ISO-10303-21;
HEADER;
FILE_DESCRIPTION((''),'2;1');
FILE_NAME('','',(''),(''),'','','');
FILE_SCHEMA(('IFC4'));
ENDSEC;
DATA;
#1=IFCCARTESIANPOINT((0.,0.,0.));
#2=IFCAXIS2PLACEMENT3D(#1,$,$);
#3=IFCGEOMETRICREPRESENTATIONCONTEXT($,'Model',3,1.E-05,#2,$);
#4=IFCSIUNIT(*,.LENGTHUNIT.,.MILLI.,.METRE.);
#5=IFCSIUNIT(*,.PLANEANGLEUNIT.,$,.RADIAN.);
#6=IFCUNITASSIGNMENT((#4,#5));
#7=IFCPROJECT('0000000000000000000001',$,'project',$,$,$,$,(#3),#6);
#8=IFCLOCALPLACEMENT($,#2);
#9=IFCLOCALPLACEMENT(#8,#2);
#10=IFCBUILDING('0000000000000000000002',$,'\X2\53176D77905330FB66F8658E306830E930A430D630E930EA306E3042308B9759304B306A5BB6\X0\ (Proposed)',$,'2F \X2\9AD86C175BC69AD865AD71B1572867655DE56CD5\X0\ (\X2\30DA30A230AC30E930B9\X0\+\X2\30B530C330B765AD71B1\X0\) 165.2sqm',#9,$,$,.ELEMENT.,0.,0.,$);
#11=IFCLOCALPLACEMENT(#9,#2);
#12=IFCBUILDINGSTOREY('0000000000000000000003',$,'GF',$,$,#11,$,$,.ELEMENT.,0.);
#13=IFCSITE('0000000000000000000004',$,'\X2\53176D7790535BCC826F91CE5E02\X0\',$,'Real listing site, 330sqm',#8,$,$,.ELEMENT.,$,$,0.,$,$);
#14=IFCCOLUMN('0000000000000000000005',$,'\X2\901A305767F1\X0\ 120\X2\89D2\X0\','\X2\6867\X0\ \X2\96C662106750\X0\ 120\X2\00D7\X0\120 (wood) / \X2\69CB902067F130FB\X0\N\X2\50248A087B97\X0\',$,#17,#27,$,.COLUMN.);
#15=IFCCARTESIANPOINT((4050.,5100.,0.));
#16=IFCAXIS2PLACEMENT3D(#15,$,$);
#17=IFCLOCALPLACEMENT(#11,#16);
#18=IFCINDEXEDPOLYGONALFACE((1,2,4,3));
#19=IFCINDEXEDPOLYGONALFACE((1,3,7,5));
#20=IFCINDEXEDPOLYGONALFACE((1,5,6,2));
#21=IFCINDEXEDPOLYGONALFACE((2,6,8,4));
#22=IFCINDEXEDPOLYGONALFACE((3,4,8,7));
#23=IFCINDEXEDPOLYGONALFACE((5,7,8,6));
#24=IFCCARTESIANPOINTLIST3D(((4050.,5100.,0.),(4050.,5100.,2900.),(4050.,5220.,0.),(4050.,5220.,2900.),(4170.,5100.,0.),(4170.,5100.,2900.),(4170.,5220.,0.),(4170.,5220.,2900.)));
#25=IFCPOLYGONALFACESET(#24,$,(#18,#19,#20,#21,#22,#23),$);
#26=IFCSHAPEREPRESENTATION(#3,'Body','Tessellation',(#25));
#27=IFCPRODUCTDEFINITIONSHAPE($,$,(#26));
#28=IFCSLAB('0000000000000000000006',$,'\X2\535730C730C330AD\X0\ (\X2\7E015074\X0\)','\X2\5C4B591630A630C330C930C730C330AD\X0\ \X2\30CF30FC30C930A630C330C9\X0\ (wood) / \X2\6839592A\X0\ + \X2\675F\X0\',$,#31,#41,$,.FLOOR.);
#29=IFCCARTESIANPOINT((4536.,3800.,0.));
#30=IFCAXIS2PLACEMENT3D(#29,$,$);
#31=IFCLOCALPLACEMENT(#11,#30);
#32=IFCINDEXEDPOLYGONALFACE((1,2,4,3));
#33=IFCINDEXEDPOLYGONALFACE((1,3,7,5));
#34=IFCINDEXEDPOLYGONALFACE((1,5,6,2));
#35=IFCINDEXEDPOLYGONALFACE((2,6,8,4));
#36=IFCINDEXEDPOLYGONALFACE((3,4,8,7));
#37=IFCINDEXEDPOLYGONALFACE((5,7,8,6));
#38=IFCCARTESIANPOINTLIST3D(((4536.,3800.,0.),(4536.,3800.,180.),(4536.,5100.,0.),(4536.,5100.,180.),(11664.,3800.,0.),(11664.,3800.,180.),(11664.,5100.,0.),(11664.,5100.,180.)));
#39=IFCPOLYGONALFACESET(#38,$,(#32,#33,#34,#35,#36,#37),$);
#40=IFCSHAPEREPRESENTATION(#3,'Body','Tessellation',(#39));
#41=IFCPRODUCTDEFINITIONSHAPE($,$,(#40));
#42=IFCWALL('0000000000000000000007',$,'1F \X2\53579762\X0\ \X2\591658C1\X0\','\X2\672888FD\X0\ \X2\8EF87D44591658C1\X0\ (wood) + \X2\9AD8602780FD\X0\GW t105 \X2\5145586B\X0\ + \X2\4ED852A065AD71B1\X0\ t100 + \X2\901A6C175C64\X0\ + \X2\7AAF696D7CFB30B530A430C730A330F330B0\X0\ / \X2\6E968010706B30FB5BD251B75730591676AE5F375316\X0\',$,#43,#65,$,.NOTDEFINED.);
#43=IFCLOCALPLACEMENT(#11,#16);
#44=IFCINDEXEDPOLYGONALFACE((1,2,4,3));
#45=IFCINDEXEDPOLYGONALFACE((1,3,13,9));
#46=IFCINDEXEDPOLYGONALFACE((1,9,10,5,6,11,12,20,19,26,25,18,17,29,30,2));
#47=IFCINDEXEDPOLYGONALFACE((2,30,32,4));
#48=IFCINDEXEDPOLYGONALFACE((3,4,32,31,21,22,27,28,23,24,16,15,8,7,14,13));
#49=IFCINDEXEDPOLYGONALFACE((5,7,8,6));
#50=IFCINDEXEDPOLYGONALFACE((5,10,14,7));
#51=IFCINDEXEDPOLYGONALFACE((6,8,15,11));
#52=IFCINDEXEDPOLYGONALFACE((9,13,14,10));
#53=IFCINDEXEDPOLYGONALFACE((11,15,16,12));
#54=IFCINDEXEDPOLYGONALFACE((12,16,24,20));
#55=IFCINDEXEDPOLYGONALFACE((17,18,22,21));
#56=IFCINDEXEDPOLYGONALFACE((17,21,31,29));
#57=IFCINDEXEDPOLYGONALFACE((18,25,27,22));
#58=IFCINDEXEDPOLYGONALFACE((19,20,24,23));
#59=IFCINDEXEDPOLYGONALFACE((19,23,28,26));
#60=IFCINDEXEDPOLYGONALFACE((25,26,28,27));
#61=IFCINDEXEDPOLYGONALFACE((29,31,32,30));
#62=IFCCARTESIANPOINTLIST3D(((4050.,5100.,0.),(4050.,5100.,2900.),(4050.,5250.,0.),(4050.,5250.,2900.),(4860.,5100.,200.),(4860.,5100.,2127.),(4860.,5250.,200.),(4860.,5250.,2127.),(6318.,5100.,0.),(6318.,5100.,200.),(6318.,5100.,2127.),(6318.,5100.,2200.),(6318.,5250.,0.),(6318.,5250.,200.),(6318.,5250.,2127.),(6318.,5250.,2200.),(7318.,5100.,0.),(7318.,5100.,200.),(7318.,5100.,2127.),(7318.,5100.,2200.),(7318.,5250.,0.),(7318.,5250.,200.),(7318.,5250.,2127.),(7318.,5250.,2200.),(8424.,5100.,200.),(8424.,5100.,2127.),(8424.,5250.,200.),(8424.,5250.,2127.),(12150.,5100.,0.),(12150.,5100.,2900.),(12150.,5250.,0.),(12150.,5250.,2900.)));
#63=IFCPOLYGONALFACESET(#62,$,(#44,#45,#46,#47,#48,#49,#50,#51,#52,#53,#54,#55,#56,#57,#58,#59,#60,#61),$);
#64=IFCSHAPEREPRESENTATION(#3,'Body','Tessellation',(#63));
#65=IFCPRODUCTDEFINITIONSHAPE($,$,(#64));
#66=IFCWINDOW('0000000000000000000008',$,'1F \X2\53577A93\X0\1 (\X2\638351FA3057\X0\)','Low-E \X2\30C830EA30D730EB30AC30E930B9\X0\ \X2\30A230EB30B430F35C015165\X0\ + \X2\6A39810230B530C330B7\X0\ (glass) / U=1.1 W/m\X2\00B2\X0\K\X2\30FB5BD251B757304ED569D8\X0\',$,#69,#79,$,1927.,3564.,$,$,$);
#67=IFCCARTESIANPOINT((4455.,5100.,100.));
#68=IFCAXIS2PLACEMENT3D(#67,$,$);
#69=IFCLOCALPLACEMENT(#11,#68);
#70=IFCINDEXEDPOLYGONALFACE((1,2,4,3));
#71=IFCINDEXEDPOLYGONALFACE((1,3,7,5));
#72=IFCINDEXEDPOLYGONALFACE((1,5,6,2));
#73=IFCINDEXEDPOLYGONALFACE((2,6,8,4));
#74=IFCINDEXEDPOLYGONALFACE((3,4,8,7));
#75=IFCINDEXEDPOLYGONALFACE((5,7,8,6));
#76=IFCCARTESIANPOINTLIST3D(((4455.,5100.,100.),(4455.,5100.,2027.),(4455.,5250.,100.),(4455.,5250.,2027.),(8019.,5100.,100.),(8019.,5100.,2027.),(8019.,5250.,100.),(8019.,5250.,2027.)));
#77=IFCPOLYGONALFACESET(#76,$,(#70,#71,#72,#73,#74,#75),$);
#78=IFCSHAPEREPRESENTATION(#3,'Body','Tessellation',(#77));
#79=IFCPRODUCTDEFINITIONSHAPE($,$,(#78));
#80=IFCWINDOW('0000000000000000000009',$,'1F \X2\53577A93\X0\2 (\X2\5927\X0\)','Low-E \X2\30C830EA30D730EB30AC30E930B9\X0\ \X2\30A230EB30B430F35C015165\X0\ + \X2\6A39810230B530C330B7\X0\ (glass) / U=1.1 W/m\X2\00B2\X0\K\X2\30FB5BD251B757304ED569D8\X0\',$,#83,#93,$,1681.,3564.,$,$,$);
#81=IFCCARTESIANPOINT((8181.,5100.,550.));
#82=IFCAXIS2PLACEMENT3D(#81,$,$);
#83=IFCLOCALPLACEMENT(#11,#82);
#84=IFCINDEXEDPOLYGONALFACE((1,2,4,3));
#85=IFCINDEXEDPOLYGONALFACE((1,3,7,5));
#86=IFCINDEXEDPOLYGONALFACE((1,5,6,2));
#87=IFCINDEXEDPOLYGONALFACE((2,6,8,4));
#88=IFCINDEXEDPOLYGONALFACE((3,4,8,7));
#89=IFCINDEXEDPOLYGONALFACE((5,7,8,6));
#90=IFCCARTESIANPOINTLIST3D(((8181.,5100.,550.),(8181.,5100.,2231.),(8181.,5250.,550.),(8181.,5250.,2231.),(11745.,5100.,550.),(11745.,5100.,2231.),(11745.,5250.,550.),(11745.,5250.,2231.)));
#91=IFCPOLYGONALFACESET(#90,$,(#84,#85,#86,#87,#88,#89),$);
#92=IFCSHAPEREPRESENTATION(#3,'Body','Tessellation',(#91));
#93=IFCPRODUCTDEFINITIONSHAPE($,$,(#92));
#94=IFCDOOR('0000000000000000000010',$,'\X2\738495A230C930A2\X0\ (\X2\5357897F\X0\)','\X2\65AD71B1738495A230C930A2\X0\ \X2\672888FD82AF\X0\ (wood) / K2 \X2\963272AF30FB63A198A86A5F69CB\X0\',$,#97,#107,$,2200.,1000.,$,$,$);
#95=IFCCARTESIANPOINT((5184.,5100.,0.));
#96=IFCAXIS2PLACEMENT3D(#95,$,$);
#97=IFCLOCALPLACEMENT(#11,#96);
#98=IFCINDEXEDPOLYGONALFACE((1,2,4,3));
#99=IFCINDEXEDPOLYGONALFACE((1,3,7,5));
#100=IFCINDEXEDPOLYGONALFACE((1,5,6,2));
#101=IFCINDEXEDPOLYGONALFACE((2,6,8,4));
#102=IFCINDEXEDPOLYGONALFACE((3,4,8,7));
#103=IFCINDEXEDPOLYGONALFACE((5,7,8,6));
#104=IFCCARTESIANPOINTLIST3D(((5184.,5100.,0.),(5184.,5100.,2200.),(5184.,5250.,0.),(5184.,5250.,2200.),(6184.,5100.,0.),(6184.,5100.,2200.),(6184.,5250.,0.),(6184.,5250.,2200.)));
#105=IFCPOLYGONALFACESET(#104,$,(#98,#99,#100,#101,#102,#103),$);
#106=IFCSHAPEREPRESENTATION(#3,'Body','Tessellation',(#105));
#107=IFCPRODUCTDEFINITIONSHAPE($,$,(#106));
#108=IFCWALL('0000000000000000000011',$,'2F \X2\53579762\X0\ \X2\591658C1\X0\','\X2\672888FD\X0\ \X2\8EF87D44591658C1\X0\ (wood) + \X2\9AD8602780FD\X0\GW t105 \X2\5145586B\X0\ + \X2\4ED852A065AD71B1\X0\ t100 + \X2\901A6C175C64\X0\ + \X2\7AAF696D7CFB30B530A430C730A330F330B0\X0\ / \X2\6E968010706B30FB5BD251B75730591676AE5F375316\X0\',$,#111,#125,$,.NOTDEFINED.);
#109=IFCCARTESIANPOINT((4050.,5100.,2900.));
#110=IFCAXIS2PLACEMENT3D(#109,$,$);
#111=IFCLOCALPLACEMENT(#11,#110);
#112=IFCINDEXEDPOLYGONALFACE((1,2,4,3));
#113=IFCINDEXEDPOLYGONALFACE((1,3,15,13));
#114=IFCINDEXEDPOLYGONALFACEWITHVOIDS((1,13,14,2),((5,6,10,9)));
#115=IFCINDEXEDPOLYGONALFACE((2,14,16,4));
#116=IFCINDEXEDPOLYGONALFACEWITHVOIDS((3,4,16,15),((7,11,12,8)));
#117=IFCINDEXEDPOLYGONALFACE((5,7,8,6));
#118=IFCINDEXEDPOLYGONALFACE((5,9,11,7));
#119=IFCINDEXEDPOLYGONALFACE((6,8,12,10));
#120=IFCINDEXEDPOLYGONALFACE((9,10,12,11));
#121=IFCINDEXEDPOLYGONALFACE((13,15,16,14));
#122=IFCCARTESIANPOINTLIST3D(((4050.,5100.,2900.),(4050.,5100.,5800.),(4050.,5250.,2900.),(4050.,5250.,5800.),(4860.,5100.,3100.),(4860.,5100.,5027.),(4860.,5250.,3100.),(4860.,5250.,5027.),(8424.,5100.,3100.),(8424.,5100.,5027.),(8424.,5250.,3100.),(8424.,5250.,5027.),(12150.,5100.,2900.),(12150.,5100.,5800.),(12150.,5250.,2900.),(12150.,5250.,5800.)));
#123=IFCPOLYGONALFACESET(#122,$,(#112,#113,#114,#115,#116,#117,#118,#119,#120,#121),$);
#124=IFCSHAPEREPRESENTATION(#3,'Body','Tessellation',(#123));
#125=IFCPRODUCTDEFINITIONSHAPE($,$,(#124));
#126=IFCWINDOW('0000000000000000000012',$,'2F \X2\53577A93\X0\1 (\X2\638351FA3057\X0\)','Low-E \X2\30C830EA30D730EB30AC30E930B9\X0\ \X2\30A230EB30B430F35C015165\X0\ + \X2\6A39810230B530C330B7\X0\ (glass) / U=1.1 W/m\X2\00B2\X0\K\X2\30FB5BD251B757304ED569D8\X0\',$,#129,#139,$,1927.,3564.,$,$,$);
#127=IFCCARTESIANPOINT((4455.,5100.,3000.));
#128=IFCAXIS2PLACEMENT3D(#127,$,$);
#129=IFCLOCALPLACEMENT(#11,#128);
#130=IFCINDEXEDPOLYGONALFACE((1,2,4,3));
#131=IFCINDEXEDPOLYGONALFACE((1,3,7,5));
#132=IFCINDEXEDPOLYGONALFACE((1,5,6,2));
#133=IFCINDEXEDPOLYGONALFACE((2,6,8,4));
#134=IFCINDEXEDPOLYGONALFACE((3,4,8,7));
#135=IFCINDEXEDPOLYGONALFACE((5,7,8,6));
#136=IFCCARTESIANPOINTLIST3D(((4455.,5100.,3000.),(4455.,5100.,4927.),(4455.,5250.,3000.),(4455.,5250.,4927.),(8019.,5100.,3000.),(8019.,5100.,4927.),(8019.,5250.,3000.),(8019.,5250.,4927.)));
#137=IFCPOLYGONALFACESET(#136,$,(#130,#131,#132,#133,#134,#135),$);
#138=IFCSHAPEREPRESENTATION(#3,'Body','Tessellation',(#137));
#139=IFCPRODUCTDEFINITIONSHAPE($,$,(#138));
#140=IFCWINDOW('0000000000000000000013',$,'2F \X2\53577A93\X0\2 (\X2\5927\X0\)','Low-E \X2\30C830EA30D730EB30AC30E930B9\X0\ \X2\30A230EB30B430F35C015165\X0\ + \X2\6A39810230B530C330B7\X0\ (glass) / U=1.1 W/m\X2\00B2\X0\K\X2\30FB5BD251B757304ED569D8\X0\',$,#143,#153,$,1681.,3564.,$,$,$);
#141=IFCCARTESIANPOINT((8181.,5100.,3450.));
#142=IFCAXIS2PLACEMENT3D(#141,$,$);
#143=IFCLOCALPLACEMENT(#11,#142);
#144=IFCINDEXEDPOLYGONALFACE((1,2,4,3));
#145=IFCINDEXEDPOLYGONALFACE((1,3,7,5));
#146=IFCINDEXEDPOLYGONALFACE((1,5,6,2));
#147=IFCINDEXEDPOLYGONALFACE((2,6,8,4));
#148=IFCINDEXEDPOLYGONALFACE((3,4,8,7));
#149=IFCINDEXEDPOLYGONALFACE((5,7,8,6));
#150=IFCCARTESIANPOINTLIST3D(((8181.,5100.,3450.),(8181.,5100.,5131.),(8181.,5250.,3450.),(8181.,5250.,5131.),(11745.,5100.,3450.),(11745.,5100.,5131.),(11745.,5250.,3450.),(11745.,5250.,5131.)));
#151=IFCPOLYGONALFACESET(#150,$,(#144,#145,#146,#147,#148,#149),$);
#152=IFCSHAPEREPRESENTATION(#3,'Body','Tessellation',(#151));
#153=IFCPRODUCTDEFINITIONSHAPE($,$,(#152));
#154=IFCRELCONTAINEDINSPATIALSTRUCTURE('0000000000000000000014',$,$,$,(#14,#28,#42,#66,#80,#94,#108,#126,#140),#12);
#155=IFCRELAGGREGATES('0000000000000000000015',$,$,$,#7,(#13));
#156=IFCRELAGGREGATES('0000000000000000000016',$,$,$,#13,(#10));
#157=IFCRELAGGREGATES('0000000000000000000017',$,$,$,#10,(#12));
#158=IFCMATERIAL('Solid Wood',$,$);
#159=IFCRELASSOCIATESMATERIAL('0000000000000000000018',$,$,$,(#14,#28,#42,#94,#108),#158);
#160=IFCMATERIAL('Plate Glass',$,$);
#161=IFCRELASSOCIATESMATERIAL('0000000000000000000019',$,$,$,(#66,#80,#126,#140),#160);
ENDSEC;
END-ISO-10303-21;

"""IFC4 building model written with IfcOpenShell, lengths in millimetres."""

from ifc_helpers import new_model, si_unit, frame, frame_2d, origin, place, context, project, spatial, rectangle, extrude, material, element, fill, save


model = new_model("IFC4")

# Units and contexts
model_context = context("Model", 3, precision=1e-05, world=origin())
ifc_project = project(units=[si_unit("LENGTHUNIT", "METRE", prefix="MILLI"), si_unit("PLANEANGLEUNIT", "RADIAN")], contexts=[model_context])

# Site, building, storey
site_placement = place(None, origin())
site = spatial("IfcSite", under=ifc_project, at=site_placement, Name="北海道富良野市", ObjectType="Real listing site, 330sqm", CompositionType="ELEMENT", RefElevation=0.0)
building_placement = place(site_placement, origin())
building = spatial("IfcBuilding", under=site, at=building_placement, Name="北海道・書斎とライブラリのある静かな家 (Proposed)", ObjectType="2F 高気密高断熱在来工法 (ペアガラス+サッシ断熱) 165.2sqm", CompositionType="ELEMENT", ElevationOfRefHeight=0.0, ElevationOfTerrain=0.0)
storey_placement = place(building_placement, origin())
storey = spatial("IfcBuildingStorey", under=building, at=storey_placement, Name="GF", CompositionType="ELEMENT", Elevation=0.0)

# Column
ifc_material_1 = material(Name="Solid Wood")
column_placement = place(storey_placement, frame((4050.0, 5100.0, 0.0)))
element("IfcColumn", 1, at=column_placement, inside=storey, material=ifc_material_1, Name="通し柱 120角", Description="桧 集成材 120×120 (wood) / 構造柱・N値計算", PredefinedType="COLUMN", context=model_context, shape_type="SweptSolid", body=[
    extrude(rectangle(XDim=120.0, YDim=120.0, at=frame_2d((60.0, 60.0))), frame((4050.0, 5100.0, 0.0)), (0.0, 0.0, 1.0), 2900.0),
])

# Slab
slab_1_placement = place(storey_placement, frame((4536.0, 3800.0, 0.0)))
element("IfcSlab", 2, at=slab_1_placement, inside=storey, material=ifc_material_1, Name="南デッキ (縁側)", Description="屋外ウッドデッキ ハードウッド (wood) / 根太 + 束", PredefinedType="FLOOR", context=model_context, shape_type="SweptSolid", body=[
    extrude(rectangle(XDim=7128.0, YDim=1300.0, at=frame_2d((3564.0, 650.0))), frame((4536.0, 3800.0, 0.0)), (0.0, 0.0, 1.0), 180.0),
])

# Wall, openings, windows, door
wall_1_placement = place(storey_placement, frame((4050.0, 5100.0, 0.0)))
wall_1 = element("IfcWall", 3, at=wall_1_placement, inside=storey, material=ifc_material_1, Name="1F 南面 外壁", Description="木製 軸組外壁 (wood) + 高性能GW t105 充填 + 付加断熱 t100 + 通気層 + 窯業系サイディング / 準耐火・寒冷地外皮強化", PredefinedType="NOTDEFINED", context=model_context, shape_type="SweptSolid", body=[
    extrude(rectangle(XDim=8100.0, YDim=150.0, at=frame_2d((4050.0, 75.0))), frame((4050.0, 5100.0, 0.0)), (0.0, 0.0, 1.0), 2900.0),
])
opening_1_placement = place(storey_placement, frame((4455.0, 5100.0, 100.0)))
opening_1 = element("IfcOpeningElement", 4, at=opening_1_placement, cuts=wall_1, PredefinedType="NOTDEFINED", context=model_context, shape_type="SweptSolid", body=[
    extrude(rectangle(XDim=3564.0, YDim=150.0, at=frame_2d((1782.0, 75.0))), frame((4455.0, 5100.0, 100.0)), (0.0, 0.0, 1.0), 1927.0),
])
opening_2_placement = place(storey_placement, frame((8181.0, 5100.0, 550.0)))
opening_2 = element("IfcOpeningElement", 5, at=opening_2_placement, cuts=wall_1, PredefinedType="NOTDEFINED", context=model_context, shape_type="SweptSolid", body=[
    extrude(rectangle(XDim=3564.0, YDim=150.0, at=frame_2d((1782.0, 75.0))), frame((8181.0, 5100.0, 550.0)), (0.0, 0.0, 1.0), 1681.0),
])
opening_3_placement = place(storey_placement, frame((5184.0, 5100.0, 0.0)))
opening_3 = element("IfcOpeningElement", 6, at=opening_3_placement, cuts=wall_1, PredefinedType="NOTDEFINED", context=model_context, shape_type="SweptSolid", body=[
    extrude(rectangle(XDim=1000.0, YDim=150.0, at=frame_2d((500.0, 75.0))), frame((5184.0, 5100.0, 0.0)), (0.0, 0.0, 1.0), 2200.0),
])
ifc_material_2 = material(Name="Plate Glass")
window_1_placement = place(storey_placement, frame((4455.0, 5100.0, 100.0)))
window_1 = element("IfcWindow", 7, at=window_1_placement, inside=storey, material=ifc_material_2, Name="1F 南窓1 (掃出し)", Description="Low-E トリプルガラス アルゴン封入 + 樹脂サッシ (glass) / U=1.1 W/m²K・寒冷地仕様", OverallHeight=1927.0, OverallWidth=3564.0, context=model_context, shape_type="SweptSolid", body=[
    extrude(rectangle(XDim=3564.0, YDim=150.0, at=frame_2d((1782.0, 75.0))), frame((4455.0, 5100.0, 100.0)), (0.0, 0.0, 1.0), 1927.0),
])
fill(opening_1, window_1)
window_2_placement = place(storey_placement, frame((8181.0, 5100.0, 550.0)))
window_2 = element("IfcWindow", 8, at=window_2_placement, inside=storey, material=ifc_material_2, Name="1F 南窓2 (大)", Description="Low-E トリプルガラス アルゴン封入 + 樹脂サッシ (glass) / U=1.1 W/m²K・寒冷地仕様", OverallHeight=1681.0, OverallWidth=3564.0, context=model_context, shape_type="SweptSolid", body=[
    extrude(rectangle(XDim=3564.0, YDim=150.0, at=frame_2d((1782.0, 75.0))), frame((8181.0, 5100.0, 550.0)), (0.0, 0.0, 1.0), 1681.0),
])
fill(opening_2, window_2)
door_placement = place(storey_placement, frame((5184.0, 5100.0, 0.0)))
door = element("IfcDoor", 9, at=door_placement, inside=storey, material=ifc_material_1, Name="玄関ドア (南西)", Description="断熱玄関ドア 木製芯 (wood) / K2 防犯・採風機構", OverallHeight=2200.0, OverallWidth=1000.0, context=model_context, shape_type="SweptSolid", body=[
    extrude(rectangle(XDim=1000.0, YDim=150.0, at=frame_2d((500.0, 75.0))), frame((5184.0, 5100.0, 0.0)), (0.0, 0.0, 1.0), 2200.0),
])
fill(opening_3, door)

# Wall, openings, windows
wall_2_placement = place(storey_placement, frame((4050.0, 5100.0, 2900.0)))
wall_2 = element("IfcWall", 10, at=wall_2_placement, inside=storey, material=ifc_material_1, Name="2F 南面 外壁", Description="木製 軸組外壁 (wood) + 高性能GW t105 充填 + 付加断熱 t100 + 通気層 + 窯業系サイディング / 準耐火・寒冷地外皮強化", PredefinedType="NOTDEFINED", context=model_context, shape_type="SweptSolid", body=[
    extrude(rectangle(XDim=8100.0, YDim=150.0, at=frame_2d((4050.0, 75.0))), frame((4050.0, 5100.0, 2900.0)), (0.0, 0.0, 1.0), 2900.0),
])
opening_4_placement = place(storey_placement, frame((4455.0, 5100.0, 3000.0)))
opening_4 = element("IfcOpeningElement", 11, at=opening_4_placement, cuts=wall_2, PredefinedType="NOTDEFINED", context=model_context, shape_type="SweptSolid", body=[
    extrude(rectangle(XDim=3564.0, YDim=150.0, at=frame_2d((1782.0, 75.0))), frame((4455.0, 5100.0, 3000.0)), (0.0, 0.0, 1.0), 1927.0),
])
opening_5_placement = place(storey_placement, frame((8181.0, 5100.0, 3450.0)))
opening_5 = element("IfcOpeningElement", 12, at=opening_5_placement, cuts=wall_2, PredefinedType="NOTDEFINED", context=model_context, shape_type="SweptSolid", body=[
    extrude(rectangle(XDim=3564.0, YDim=150.0, at=frame_2d((1782.0, 75.0))), frame((8181.0, 5100.0, 3450.0)), (0.0, 0.0, 1.0), 1681.0),
])
window_3_placement = place(storey_placement, frame((4455.0, 5100.0, 3000.0)))
window_3 = element("IfcWindow", 13, at=window_3_placement, inside=storey, material=ifc_material_2, Name="2F 南窓1 (掃出し)", Description="Low-E トリプルガラス アルゴン封入 + 樹脂サッシ (glass) / U=1.1 W/m²K・寒冷地仕様", OverallHeight=1927.0, OverallWidth=3564.0, context=model_context, shape_type="SweptSolid", body=[
    extrude(rectangle(XDim=3564.0, YDim=150.0, at=frame_2d((1782.0, 75.0))), frame((4455.0, 5100.0, 3000.0)), (0.0, 0.0, 1.0), 1927.0),
])
fill(opening_4, window_3)
window_4_placement = place(storey_placement, frame((8181.0, 5100.0, 3450.0)))
window_4 = element("IfcWindow", 14, at=window_4_placement, inside=storey, material=ifc_material_2, Name="2F 南窓2 (大)", Description="Low-E トリプルガラス アルゴン封入 + 樹脂サッシ (glass) / U=1.1 W/m²K・寒冷地仕様", OverallHeight=1681.0, OverallWidth=3564.0, context=model_context, shape_type="SweptSolid", body=[
    extrude(rectangle(XDim=3564.0, YDim=150.0, at=frame_2d((1782.0, 75.0))), frame((8181.0, 5100.0, 3450.0)), (0.0, 0.0, 1.0), 1681.0),
])
fill(opening_5, window_4)

save(model, "model.ifc")
